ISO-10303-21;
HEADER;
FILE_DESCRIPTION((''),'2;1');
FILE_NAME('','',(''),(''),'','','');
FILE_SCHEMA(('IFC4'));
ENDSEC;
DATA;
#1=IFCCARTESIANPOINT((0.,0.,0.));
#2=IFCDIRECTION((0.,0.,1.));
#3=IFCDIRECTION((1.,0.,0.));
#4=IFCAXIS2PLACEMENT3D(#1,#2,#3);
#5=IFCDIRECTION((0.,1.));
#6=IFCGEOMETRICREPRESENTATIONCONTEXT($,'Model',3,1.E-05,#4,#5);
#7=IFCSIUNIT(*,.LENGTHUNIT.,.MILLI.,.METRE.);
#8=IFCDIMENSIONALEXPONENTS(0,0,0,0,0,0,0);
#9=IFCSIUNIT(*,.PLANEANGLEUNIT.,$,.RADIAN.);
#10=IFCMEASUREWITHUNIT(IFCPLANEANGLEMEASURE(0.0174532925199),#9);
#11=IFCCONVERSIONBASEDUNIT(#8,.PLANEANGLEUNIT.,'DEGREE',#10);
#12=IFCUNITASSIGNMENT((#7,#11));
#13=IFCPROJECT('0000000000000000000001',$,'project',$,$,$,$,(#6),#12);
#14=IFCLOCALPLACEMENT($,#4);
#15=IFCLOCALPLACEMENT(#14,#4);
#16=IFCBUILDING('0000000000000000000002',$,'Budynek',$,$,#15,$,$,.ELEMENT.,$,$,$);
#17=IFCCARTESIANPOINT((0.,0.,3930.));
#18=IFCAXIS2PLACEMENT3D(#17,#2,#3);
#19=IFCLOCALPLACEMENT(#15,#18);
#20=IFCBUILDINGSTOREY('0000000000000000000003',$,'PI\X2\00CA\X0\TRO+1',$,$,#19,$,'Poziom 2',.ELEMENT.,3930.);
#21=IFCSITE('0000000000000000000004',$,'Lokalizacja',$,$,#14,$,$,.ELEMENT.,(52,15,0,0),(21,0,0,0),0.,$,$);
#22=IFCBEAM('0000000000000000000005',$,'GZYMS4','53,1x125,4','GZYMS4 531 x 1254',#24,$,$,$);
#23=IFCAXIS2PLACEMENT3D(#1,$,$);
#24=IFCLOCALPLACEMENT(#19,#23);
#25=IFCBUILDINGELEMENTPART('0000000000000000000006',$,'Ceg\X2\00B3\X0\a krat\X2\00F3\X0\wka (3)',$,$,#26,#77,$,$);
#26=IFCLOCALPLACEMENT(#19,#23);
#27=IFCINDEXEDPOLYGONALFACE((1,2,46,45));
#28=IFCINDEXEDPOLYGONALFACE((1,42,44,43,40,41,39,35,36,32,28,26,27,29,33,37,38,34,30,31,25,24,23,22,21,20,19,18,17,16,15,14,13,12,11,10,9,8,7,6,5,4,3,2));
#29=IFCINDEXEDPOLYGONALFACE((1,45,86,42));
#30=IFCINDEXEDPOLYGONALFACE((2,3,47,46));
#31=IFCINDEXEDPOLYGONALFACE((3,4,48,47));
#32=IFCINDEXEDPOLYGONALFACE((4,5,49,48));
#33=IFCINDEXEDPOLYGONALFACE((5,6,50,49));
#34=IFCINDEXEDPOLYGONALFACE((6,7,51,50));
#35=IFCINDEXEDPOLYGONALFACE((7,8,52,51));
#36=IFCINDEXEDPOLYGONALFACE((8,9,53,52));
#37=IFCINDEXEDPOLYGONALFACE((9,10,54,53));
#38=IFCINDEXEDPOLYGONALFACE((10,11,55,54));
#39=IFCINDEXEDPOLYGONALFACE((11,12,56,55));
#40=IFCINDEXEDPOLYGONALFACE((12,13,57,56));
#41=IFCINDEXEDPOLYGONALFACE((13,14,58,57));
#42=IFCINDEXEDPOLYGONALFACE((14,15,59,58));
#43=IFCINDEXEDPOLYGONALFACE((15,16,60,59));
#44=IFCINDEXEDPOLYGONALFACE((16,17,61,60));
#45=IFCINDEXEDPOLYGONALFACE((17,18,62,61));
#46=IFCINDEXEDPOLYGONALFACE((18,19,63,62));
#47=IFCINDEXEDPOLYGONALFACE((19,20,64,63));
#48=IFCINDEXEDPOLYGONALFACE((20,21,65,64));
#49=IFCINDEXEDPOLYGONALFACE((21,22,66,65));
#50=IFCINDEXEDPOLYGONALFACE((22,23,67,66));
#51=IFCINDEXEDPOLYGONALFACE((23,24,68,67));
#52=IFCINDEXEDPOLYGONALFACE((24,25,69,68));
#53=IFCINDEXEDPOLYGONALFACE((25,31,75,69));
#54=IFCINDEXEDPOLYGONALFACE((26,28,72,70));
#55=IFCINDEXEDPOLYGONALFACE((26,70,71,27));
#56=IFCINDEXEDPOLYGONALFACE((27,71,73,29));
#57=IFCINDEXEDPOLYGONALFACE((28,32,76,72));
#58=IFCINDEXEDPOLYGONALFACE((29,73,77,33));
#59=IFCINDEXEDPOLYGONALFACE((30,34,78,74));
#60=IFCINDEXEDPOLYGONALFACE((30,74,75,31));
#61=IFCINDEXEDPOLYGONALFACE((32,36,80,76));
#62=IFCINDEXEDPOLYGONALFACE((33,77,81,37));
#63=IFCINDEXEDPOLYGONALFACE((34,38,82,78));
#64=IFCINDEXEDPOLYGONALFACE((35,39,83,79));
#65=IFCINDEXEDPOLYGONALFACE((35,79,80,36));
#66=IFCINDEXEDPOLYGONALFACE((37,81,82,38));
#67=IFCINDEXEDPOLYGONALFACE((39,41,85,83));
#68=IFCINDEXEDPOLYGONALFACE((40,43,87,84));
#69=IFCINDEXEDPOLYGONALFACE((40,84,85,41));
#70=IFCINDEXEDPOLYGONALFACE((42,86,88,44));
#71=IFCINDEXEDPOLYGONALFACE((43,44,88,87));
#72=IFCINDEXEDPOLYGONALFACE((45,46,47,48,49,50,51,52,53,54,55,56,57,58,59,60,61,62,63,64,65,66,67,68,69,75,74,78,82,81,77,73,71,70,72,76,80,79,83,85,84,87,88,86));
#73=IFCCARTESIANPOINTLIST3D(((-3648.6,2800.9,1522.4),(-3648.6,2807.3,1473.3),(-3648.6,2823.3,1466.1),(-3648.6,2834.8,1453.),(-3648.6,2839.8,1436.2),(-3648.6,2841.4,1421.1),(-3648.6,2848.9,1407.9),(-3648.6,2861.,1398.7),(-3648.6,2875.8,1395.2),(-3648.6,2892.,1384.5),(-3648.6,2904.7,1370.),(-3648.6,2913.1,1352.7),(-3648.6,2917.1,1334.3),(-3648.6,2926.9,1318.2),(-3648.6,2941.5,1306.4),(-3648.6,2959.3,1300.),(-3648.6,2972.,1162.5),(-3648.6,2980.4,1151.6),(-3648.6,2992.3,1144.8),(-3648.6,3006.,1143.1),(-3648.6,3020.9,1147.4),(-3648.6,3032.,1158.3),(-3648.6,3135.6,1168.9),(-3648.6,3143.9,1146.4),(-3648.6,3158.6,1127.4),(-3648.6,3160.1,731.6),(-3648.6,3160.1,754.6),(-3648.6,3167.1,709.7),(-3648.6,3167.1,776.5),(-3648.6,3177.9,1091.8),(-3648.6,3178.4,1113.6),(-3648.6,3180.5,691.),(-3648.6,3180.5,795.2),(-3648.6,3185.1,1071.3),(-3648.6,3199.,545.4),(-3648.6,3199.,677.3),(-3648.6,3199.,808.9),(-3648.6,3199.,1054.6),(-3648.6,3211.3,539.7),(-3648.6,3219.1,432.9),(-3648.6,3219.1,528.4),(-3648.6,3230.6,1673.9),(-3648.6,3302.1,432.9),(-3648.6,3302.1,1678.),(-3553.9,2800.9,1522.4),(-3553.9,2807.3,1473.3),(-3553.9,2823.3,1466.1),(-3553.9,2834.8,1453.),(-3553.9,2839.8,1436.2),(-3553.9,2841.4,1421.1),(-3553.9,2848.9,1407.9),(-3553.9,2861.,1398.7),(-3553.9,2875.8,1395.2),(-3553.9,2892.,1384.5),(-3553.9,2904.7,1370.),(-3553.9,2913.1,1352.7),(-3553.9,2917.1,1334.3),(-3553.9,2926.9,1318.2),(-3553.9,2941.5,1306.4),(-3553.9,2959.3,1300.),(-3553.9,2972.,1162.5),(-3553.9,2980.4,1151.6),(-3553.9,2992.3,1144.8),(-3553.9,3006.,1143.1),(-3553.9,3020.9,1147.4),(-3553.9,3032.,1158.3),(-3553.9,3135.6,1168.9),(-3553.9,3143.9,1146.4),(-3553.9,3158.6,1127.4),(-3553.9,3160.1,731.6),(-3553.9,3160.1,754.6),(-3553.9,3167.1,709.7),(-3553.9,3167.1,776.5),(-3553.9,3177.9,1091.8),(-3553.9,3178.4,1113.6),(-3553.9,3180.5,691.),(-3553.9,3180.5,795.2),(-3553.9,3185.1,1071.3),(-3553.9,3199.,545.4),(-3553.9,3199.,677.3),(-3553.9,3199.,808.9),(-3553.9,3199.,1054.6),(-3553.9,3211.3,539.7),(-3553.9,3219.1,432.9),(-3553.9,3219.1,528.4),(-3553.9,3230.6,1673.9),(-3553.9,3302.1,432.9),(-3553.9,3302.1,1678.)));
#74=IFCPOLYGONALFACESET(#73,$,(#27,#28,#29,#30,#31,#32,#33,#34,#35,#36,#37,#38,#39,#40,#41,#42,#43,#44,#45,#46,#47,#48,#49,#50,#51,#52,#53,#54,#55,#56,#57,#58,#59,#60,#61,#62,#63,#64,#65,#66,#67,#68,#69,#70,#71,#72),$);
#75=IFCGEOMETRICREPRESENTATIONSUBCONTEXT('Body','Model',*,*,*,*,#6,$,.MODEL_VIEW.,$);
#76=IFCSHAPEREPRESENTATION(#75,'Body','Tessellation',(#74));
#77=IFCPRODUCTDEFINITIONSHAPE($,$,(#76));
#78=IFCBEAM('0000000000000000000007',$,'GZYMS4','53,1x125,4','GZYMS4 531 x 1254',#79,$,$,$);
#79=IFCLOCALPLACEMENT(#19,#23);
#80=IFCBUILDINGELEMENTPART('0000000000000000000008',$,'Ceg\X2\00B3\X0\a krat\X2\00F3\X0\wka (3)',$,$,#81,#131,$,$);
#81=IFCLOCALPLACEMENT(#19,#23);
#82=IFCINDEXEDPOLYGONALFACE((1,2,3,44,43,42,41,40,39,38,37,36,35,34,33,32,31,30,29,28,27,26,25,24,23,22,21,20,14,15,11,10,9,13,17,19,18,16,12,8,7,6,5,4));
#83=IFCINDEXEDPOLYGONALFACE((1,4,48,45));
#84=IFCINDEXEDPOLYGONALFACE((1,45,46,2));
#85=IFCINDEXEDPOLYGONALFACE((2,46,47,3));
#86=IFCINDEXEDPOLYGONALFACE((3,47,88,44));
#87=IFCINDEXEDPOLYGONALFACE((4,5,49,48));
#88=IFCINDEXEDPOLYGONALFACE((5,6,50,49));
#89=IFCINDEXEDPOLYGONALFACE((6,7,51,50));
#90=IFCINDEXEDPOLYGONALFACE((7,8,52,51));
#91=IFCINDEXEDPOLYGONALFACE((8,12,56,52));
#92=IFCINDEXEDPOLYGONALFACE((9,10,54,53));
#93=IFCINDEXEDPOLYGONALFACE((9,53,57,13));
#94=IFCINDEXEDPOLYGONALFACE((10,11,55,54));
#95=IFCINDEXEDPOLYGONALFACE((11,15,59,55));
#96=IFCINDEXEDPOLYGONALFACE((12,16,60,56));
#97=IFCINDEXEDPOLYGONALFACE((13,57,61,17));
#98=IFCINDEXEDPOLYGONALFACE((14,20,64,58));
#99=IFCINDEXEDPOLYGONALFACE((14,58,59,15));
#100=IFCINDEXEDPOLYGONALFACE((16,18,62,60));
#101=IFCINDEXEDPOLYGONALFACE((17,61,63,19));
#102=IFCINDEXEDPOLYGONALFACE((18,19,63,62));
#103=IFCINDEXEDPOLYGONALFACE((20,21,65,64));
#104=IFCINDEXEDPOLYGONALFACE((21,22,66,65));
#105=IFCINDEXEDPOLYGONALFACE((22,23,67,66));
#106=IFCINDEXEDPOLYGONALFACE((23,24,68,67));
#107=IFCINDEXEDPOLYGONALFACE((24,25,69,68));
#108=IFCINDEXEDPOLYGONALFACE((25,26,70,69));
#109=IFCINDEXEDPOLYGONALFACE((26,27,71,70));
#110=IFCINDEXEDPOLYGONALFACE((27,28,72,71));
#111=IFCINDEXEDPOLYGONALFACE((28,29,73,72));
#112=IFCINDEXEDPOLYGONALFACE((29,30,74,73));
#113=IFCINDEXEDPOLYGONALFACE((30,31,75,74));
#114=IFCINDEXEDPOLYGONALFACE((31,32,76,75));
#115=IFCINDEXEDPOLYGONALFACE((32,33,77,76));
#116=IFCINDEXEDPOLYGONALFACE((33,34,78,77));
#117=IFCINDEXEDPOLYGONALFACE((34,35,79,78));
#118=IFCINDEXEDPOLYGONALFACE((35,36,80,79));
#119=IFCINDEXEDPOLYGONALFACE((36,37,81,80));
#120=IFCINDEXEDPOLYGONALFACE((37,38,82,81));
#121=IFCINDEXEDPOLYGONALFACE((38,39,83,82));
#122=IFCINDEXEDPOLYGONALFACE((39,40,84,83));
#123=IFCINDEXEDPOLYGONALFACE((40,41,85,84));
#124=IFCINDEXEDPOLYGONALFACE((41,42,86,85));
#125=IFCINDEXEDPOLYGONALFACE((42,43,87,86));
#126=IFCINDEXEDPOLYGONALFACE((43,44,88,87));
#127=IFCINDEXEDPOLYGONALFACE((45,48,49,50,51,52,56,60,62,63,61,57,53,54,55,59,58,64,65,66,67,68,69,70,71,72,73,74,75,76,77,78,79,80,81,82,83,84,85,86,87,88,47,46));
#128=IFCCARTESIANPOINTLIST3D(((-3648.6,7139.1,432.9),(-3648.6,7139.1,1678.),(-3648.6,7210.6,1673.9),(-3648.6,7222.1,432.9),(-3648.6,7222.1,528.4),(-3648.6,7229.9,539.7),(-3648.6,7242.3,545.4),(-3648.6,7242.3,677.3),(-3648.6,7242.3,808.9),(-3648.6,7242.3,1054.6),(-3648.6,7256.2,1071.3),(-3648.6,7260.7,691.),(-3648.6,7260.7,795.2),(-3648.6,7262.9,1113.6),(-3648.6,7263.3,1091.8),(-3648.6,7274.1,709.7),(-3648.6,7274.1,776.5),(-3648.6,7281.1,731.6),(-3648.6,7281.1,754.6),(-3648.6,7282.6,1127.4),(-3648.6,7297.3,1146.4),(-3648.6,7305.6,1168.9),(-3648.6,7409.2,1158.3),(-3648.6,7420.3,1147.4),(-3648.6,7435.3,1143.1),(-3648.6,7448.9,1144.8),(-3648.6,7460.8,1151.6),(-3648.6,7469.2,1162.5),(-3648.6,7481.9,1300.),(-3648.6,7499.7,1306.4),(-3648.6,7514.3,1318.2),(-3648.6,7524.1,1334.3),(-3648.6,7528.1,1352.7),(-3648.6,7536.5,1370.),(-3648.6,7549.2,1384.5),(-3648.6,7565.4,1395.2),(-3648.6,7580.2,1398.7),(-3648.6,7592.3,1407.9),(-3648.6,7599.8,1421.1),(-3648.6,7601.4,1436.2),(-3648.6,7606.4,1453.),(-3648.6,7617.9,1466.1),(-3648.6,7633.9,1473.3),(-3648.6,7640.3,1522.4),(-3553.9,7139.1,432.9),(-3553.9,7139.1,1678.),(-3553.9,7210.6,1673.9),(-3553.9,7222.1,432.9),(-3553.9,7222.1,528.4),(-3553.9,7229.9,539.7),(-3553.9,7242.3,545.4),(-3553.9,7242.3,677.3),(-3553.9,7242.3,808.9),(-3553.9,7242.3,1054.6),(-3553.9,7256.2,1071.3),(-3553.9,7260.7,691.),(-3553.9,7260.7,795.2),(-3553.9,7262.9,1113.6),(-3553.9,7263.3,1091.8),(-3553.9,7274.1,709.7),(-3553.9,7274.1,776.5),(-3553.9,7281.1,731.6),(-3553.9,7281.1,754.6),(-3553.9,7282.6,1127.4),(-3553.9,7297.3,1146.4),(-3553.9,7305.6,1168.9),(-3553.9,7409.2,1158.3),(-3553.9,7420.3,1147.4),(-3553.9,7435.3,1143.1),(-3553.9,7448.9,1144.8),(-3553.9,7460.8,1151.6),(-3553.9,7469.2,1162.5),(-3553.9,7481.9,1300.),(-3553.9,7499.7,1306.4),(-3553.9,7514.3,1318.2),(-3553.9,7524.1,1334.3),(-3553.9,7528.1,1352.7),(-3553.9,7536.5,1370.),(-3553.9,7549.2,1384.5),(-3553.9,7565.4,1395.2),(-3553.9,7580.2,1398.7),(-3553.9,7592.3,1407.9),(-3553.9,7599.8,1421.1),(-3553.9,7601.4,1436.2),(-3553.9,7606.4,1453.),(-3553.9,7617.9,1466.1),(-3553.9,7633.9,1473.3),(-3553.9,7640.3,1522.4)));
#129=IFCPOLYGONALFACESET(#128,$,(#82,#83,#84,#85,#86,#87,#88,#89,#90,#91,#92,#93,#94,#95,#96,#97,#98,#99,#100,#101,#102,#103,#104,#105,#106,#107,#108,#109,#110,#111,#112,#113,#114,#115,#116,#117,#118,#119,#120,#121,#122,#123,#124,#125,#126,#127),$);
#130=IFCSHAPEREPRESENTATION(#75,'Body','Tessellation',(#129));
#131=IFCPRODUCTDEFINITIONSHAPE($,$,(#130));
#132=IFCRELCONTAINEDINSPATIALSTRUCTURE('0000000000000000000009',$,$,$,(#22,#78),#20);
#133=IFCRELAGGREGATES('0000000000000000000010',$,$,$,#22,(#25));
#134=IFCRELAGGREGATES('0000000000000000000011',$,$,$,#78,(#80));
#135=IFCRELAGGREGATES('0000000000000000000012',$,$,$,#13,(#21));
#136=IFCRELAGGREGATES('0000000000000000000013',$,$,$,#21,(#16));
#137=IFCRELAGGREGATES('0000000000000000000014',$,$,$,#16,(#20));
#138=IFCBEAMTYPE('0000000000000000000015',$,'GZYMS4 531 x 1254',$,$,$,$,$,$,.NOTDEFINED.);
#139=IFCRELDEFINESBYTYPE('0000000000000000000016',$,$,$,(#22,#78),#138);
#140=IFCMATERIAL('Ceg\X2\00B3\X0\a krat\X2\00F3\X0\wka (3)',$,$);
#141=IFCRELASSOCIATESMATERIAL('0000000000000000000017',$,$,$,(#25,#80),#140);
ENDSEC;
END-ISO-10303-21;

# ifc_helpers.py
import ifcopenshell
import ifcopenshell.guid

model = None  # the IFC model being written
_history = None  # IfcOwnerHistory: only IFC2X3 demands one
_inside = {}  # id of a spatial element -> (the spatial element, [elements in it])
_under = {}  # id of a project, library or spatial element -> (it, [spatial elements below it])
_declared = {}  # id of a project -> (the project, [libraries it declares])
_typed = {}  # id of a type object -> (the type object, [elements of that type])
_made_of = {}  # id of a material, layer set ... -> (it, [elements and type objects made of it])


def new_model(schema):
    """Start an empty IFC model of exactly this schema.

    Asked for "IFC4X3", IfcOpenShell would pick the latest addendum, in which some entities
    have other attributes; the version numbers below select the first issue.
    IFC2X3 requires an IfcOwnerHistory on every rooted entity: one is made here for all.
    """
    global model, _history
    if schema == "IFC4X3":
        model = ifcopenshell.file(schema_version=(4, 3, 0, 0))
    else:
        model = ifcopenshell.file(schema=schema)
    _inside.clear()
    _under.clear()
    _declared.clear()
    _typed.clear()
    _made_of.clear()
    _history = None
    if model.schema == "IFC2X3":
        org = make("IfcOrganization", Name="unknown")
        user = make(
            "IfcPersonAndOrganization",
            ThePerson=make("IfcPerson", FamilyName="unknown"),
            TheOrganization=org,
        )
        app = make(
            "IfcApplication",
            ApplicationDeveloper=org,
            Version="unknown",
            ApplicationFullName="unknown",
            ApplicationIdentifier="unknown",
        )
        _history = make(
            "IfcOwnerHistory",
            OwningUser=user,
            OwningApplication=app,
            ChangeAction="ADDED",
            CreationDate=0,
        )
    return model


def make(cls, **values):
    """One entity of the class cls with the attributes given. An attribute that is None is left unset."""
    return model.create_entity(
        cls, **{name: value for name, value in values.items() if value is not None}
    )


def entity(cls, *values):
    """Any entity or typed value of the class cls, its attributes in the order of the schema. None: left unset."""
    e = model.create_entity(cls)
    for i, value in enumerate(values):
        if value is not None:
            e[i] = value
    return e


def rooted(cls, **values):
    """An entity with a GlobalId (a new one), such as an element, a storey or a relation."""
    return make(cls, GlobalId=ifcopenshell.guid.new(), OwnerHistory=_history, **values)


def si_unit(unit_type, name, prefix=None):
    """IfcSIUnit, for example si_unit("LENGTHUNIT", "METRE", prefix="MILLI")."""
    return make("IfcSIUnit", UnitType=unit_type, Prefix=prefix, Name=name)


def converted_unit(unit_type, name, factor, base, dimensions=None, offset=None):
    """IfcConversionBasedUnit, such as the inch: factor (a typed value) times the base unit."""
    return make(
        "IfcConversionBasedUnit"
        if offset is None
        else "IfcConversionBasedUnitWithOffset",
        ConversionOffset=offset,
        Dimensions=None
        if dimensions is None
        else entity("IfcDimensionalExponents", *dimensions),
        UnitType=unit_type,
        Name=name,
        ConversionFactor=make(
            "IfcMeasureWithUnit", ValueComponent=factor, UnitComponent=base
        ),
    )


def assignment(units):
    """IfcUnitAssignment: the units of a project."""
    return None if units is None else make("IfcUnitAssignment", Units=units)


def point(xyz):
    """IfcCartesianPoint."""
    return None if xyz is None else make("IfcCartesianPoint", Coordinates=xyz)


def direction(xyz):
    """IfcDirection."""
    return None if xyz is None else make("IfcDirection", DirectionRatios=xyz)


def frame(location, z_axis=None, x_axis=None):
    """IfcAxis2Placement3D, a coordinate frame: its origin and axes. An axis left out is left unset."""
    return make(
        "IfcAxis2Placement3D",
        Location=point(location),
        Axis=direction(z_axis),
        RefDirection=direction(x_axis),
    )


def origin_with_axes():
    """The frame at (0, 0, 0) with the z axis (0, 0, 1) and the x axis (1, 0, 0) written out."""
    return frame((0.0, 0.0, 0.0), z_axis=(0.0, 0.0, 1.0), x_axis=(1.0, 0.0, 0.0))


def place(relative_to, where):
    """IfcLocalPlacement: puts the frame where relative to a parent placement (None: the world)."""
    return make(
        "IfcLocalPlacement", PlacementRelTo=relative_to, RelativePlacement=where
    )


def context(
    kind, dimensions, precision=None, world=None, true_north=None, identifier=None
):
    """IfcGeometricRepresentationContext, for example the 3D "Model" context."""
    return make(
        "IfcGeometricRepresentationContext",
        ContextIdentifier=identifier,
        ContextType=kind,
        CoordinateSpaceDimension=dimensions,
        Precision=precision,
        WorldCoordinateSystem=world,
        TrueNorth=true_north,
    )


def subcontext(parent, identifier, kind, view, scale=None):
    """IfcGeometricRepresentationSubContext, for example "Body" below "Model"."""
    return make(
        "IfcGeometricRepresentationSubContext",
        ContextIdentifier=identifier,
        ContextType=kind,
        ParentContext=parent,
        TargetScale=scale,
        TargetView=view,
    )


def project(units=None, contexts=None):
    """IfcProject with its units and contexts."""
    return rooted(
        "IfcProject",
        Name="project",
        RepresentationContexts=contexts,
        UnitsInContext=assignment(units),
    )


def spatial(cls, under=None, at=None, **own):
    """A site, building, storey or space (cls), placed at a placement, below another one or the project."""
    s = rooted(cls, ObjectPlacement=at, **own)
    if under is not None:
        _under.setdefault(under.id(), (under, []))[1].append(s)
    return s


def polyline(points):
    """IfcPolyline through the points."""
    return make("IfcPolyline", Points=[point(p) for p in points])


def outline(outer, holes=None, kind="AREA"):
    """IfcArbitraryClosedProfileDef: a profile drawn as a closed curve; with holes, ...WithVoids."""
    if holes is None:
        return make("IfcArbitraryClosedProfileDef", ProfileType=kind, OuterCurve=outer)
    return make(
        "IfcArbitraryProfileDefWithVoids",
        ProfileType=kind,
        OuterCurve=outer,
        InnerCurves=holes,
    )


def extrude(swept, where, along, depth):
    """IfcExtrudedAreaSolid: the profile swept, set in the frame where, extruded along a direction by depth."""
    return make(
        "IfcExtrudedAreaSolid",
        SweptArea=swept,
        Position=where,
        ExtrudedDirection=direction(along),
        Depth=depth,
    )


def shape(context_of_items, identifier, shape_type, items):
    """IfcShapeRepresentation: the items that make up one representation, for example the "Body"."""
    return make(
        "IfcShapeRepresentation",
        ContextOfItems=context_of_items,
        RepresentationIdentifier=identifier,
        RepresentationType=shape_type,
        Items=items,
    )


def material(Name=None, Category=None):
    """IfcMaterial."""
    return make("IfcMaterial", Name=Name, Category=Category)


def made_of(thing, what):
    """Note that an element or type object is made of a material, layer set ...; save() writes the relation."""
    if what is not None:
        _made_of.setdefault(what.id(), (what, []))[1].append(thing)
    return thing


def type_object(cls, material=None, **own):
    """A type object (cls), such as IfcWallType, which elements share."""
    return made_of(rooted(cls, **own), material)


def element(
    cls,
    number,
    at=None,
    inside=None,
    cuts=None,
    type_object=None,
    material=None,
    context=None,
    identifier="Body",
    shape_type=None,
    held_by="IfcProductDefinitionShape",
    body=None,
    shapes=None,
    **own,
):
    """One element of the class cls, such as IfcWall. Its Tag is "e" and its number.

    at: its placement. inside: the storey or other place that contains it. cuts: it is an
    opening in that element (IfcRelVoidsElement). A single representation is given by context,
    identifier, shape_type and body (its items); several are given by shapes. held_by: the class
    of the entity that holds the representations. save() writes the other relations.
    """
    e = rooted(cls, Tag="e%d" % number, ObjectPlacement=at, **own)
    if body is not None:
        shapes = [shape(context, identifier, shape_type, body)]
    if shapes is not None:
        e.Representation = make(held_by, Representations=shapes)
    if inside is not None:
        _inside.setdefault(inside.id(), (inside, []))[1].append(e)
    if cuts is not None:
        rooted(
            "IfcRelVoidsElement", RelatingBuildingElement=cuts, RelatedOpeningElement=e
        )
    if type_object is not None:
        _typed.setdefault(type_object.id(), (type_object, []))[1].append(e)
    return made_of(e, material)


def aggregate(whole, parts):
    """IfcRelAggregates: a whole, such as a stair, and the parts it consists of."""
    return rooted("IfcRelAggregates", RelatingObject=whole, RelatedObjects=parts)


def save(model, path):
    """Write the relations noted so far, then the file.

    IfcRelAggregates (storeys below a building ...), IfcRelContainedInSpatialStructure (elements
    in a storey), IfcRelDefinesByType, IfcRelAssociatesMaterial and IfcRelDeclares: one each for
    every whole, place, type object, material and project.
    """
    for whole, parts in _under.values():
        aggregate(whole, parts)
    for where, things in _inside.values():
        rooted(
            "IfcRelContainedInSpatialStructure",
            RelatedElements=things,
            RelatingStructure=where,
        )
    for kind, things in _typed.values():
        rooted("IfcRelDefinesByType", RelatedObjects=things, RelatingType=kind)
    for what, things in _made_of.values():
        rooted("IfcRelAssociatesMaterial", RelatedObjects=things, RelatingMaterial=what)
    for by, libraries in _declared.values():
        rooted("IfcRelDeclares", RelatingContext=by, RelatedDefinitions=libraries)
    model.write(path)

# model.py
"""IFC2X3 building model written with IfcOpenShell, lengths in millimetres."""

from ifc_helpers import new_model, entity, si_unit, converted_unit, direction, frame, origin_with_axes, place, context, subcontext, project, spatial, polyline, outline, extrude, material, type_object, element, aggregate, save


model = new_model("IFC2X3")

# Units and contexts
model_context = context("Model", 3, precision=1e-05, world=origin_with_axes(), true_north=direction((0.0, 1.0)))
body_context = subcontext(model_context, "Body", "Model", "MODEL_VIEW")
ifc_project = project(units=[si_unit("LENGTHUNIT", "METRE", prefix="MILLI"), converted_unit("PLANEANGLEUNIT", "DEGREE", entity("IfcPlaneAngleMeasure", 0.0174532925199), si_unit("PLANEANGLEUNIT", "RADIAN"), dimensions=[0, 0, 0, 0, 0, 0, 0])], contexts=[model_context])

# Site, building, storey
site_placement = place(None, origin_with_axes())
site = spatial("IfcSite", under=ifc_project, at=site_placement, Name="Lokalizacja", CompositionType="ELEMENT", RefLatitude=(52, 15, 0, 0), RefLongitude=(21, 0, 0, 0), RefElevation=0.0)
building_placement = place(site_placement, origin_with_axes())
building = spatial("IfcBuilding", under=site, at=building_placement, Name="Budynek", CompositionType="ELEMENT")
storey_placement = place(building_placement, frame((0.0, 0.0, 3930.0), z_axis=(0.0, 0.0, 1.0), x_axis=(1.0, 0.0, 0.0)))
storey = spatial("IfcBuildingStorey", under=building, at=storey_placement, Name="PIÊTRO+1", LongName="Poziom 2", CompositionType="ELEMENT", Elevation=3930.0)

# Shared definitions
ifc_material_1 = material(Name="Ceg³a kratówka (3)")

# Beams, building element parts
beam_type_1 = type_object("IfcBeamType", Name="GZYMS4 531 x 1254", PredefinedType="NOTDEFINED")
beam_1_placement = place(storey_placement, frame((-3553.9, 3207.4, 432.9), z_axis=(0.0, 0.0, 1.0), x_axis=(0.0, 1.0, 0.0)))
beam_1 = element("IfcBeam", 1, at=beam_1_placement, inside=storey, type_object=beam_type_1, Name="GZYMS4", Description="53,1x125,4", ObjectType="GZYMS4 531 x 1254")
building_element_part_1_placement = place(beam_1_placement, origin_with_axes())
building_element_part_1 = element("IfcBuildingElementPart", 2, at=building_element_part_1_placement, material=ifc_material_1, Name="Ceg³a kratówka (3)", context=body_context, shape_type="SweptSolid", body=[
    extrude(outline(polyline([(-406.6, 1089.5), (-400.1, 1040.4), (-384.2, 1033.2), (-372.6, 1020.1), (-367.6, 1003.3), (-366.0, 988.2), (-358.5, 975.0), (-346.4, 965.8), (-331.6, 962.3), (-315.5, 951.6), (-302.7, 937.1), (-294.3, 919.8), (-290.4, 901.4), (-280.5, 885.3), (-265.9, 873.5), (-248.2, 867.1), (-235.4, 729.6), (-227.0, 718.7), (-215.1, 711.9), (-201.5, 710.2), (-186.5, 714.5), (-175.4, 725.4), (-71.9, 736.0), (-63.5, 713.5), (-48.8, 694.5), (-29.1, 680.7), (-29.5, 658.9), (-22.4, 638.4), (-8.5, 621.7), (-8.5, 376.0), (-26.9, 362.3), (-40.3, 343.6), (-47.3, 321.7), (-47.3, 298.7), (-40.3, 276.8), (-26.9, 258.1), (-8.5, 244.4), (-8.5, 112.5), (3.9, 106.8), (11.6, 95.5), (11.6, 0.0), (94.6, 0.0), (94.6, 1245.1), (23.1, 1241.0), (-406.6, 1089.5)])), frame((0.0, 94.6, 0.0), z_axis=(0.0, -1.0, 0.0), x_axis=(1.0, 0.0, 0.0)), (0.0, 0.0, 1.0), 94.6),
])
aggregate(beam_1, [building_element_part_1])
beam_2_placement = place(storey_placement, frame((-3553.9, 7233.8, 432.9), z_axis=(0.0, 0.0, 1.0), x_axis=(0.0, 1.0, 0.0)))
beam_2 = element("IfcBeam", 3, at=beam_2_placement, inside=storey, type_object=beam_type_1, Name="GZYMS4", Description="53,1x125,4", ObjectType="GZYMS4 531 x 1254")
building_element_part_2_placement = place(beam_2_placement, origin_with_axes())
building_element_part_2 = element("IfcBuildingElementPart", 4, at=building_element_part_2_placement, material=ifc_material_1, Name="Ceg³a kratówka (3)", context=body_context, shape_type="SweptSolid", body=[
    extrude(outline(polyline([(406.6, 1089.5), (-23.1, 1241.0), (-94.6, 1245.1), (-94.6, 0.0), (-11.6, 0.0), (-11.6, 95.5), (-3.9, 106.8), (8.5, 112.5), (8.5, 244.4), (26.9, 258.1), (40.3, 276.8), (47.3, 298.7), (47.3, 321.7), (40.3, 343.6), (26.9, 362.3), (8.5, 376.0), (8.5, 621.7), (22.4, 638.4), (29.5, 658.9), (29.1, 680.7), (48.8, 694.5), (63.5, 713.5), (71.9, 736.0), (175.4, 725.4), (186.5, 714.5), (201.5, 710.2), (215.1, 711.9), (227.0, 718.7), (235.4, 729.6), (248.2, 867.1), (265.9, 873.5), (280.5, 885.3), (290.4, 901.4), (294.3, 919.8), (302.7, 937.1), (315.5, 951.6), (331.6, 962.3), (346.4, 965.8), (358.5, 975.0), (366.0, 988.2), (367.6, 1003.3), (372.6, 1020.1), (384.2, 1033.2), (400.1, 1040.4), (406.6, 1089.5)])), frame((0.0, 94.6, 0.0), z_axis=(0.0, -1.0, 0.0), x_axis=(1.0, 0.0, 0.0)), (0.0, 0.0, 1.0), 94.6),
])
aggregate(beam_2, [building_element_part_2])

save(model, "model.ifc")
